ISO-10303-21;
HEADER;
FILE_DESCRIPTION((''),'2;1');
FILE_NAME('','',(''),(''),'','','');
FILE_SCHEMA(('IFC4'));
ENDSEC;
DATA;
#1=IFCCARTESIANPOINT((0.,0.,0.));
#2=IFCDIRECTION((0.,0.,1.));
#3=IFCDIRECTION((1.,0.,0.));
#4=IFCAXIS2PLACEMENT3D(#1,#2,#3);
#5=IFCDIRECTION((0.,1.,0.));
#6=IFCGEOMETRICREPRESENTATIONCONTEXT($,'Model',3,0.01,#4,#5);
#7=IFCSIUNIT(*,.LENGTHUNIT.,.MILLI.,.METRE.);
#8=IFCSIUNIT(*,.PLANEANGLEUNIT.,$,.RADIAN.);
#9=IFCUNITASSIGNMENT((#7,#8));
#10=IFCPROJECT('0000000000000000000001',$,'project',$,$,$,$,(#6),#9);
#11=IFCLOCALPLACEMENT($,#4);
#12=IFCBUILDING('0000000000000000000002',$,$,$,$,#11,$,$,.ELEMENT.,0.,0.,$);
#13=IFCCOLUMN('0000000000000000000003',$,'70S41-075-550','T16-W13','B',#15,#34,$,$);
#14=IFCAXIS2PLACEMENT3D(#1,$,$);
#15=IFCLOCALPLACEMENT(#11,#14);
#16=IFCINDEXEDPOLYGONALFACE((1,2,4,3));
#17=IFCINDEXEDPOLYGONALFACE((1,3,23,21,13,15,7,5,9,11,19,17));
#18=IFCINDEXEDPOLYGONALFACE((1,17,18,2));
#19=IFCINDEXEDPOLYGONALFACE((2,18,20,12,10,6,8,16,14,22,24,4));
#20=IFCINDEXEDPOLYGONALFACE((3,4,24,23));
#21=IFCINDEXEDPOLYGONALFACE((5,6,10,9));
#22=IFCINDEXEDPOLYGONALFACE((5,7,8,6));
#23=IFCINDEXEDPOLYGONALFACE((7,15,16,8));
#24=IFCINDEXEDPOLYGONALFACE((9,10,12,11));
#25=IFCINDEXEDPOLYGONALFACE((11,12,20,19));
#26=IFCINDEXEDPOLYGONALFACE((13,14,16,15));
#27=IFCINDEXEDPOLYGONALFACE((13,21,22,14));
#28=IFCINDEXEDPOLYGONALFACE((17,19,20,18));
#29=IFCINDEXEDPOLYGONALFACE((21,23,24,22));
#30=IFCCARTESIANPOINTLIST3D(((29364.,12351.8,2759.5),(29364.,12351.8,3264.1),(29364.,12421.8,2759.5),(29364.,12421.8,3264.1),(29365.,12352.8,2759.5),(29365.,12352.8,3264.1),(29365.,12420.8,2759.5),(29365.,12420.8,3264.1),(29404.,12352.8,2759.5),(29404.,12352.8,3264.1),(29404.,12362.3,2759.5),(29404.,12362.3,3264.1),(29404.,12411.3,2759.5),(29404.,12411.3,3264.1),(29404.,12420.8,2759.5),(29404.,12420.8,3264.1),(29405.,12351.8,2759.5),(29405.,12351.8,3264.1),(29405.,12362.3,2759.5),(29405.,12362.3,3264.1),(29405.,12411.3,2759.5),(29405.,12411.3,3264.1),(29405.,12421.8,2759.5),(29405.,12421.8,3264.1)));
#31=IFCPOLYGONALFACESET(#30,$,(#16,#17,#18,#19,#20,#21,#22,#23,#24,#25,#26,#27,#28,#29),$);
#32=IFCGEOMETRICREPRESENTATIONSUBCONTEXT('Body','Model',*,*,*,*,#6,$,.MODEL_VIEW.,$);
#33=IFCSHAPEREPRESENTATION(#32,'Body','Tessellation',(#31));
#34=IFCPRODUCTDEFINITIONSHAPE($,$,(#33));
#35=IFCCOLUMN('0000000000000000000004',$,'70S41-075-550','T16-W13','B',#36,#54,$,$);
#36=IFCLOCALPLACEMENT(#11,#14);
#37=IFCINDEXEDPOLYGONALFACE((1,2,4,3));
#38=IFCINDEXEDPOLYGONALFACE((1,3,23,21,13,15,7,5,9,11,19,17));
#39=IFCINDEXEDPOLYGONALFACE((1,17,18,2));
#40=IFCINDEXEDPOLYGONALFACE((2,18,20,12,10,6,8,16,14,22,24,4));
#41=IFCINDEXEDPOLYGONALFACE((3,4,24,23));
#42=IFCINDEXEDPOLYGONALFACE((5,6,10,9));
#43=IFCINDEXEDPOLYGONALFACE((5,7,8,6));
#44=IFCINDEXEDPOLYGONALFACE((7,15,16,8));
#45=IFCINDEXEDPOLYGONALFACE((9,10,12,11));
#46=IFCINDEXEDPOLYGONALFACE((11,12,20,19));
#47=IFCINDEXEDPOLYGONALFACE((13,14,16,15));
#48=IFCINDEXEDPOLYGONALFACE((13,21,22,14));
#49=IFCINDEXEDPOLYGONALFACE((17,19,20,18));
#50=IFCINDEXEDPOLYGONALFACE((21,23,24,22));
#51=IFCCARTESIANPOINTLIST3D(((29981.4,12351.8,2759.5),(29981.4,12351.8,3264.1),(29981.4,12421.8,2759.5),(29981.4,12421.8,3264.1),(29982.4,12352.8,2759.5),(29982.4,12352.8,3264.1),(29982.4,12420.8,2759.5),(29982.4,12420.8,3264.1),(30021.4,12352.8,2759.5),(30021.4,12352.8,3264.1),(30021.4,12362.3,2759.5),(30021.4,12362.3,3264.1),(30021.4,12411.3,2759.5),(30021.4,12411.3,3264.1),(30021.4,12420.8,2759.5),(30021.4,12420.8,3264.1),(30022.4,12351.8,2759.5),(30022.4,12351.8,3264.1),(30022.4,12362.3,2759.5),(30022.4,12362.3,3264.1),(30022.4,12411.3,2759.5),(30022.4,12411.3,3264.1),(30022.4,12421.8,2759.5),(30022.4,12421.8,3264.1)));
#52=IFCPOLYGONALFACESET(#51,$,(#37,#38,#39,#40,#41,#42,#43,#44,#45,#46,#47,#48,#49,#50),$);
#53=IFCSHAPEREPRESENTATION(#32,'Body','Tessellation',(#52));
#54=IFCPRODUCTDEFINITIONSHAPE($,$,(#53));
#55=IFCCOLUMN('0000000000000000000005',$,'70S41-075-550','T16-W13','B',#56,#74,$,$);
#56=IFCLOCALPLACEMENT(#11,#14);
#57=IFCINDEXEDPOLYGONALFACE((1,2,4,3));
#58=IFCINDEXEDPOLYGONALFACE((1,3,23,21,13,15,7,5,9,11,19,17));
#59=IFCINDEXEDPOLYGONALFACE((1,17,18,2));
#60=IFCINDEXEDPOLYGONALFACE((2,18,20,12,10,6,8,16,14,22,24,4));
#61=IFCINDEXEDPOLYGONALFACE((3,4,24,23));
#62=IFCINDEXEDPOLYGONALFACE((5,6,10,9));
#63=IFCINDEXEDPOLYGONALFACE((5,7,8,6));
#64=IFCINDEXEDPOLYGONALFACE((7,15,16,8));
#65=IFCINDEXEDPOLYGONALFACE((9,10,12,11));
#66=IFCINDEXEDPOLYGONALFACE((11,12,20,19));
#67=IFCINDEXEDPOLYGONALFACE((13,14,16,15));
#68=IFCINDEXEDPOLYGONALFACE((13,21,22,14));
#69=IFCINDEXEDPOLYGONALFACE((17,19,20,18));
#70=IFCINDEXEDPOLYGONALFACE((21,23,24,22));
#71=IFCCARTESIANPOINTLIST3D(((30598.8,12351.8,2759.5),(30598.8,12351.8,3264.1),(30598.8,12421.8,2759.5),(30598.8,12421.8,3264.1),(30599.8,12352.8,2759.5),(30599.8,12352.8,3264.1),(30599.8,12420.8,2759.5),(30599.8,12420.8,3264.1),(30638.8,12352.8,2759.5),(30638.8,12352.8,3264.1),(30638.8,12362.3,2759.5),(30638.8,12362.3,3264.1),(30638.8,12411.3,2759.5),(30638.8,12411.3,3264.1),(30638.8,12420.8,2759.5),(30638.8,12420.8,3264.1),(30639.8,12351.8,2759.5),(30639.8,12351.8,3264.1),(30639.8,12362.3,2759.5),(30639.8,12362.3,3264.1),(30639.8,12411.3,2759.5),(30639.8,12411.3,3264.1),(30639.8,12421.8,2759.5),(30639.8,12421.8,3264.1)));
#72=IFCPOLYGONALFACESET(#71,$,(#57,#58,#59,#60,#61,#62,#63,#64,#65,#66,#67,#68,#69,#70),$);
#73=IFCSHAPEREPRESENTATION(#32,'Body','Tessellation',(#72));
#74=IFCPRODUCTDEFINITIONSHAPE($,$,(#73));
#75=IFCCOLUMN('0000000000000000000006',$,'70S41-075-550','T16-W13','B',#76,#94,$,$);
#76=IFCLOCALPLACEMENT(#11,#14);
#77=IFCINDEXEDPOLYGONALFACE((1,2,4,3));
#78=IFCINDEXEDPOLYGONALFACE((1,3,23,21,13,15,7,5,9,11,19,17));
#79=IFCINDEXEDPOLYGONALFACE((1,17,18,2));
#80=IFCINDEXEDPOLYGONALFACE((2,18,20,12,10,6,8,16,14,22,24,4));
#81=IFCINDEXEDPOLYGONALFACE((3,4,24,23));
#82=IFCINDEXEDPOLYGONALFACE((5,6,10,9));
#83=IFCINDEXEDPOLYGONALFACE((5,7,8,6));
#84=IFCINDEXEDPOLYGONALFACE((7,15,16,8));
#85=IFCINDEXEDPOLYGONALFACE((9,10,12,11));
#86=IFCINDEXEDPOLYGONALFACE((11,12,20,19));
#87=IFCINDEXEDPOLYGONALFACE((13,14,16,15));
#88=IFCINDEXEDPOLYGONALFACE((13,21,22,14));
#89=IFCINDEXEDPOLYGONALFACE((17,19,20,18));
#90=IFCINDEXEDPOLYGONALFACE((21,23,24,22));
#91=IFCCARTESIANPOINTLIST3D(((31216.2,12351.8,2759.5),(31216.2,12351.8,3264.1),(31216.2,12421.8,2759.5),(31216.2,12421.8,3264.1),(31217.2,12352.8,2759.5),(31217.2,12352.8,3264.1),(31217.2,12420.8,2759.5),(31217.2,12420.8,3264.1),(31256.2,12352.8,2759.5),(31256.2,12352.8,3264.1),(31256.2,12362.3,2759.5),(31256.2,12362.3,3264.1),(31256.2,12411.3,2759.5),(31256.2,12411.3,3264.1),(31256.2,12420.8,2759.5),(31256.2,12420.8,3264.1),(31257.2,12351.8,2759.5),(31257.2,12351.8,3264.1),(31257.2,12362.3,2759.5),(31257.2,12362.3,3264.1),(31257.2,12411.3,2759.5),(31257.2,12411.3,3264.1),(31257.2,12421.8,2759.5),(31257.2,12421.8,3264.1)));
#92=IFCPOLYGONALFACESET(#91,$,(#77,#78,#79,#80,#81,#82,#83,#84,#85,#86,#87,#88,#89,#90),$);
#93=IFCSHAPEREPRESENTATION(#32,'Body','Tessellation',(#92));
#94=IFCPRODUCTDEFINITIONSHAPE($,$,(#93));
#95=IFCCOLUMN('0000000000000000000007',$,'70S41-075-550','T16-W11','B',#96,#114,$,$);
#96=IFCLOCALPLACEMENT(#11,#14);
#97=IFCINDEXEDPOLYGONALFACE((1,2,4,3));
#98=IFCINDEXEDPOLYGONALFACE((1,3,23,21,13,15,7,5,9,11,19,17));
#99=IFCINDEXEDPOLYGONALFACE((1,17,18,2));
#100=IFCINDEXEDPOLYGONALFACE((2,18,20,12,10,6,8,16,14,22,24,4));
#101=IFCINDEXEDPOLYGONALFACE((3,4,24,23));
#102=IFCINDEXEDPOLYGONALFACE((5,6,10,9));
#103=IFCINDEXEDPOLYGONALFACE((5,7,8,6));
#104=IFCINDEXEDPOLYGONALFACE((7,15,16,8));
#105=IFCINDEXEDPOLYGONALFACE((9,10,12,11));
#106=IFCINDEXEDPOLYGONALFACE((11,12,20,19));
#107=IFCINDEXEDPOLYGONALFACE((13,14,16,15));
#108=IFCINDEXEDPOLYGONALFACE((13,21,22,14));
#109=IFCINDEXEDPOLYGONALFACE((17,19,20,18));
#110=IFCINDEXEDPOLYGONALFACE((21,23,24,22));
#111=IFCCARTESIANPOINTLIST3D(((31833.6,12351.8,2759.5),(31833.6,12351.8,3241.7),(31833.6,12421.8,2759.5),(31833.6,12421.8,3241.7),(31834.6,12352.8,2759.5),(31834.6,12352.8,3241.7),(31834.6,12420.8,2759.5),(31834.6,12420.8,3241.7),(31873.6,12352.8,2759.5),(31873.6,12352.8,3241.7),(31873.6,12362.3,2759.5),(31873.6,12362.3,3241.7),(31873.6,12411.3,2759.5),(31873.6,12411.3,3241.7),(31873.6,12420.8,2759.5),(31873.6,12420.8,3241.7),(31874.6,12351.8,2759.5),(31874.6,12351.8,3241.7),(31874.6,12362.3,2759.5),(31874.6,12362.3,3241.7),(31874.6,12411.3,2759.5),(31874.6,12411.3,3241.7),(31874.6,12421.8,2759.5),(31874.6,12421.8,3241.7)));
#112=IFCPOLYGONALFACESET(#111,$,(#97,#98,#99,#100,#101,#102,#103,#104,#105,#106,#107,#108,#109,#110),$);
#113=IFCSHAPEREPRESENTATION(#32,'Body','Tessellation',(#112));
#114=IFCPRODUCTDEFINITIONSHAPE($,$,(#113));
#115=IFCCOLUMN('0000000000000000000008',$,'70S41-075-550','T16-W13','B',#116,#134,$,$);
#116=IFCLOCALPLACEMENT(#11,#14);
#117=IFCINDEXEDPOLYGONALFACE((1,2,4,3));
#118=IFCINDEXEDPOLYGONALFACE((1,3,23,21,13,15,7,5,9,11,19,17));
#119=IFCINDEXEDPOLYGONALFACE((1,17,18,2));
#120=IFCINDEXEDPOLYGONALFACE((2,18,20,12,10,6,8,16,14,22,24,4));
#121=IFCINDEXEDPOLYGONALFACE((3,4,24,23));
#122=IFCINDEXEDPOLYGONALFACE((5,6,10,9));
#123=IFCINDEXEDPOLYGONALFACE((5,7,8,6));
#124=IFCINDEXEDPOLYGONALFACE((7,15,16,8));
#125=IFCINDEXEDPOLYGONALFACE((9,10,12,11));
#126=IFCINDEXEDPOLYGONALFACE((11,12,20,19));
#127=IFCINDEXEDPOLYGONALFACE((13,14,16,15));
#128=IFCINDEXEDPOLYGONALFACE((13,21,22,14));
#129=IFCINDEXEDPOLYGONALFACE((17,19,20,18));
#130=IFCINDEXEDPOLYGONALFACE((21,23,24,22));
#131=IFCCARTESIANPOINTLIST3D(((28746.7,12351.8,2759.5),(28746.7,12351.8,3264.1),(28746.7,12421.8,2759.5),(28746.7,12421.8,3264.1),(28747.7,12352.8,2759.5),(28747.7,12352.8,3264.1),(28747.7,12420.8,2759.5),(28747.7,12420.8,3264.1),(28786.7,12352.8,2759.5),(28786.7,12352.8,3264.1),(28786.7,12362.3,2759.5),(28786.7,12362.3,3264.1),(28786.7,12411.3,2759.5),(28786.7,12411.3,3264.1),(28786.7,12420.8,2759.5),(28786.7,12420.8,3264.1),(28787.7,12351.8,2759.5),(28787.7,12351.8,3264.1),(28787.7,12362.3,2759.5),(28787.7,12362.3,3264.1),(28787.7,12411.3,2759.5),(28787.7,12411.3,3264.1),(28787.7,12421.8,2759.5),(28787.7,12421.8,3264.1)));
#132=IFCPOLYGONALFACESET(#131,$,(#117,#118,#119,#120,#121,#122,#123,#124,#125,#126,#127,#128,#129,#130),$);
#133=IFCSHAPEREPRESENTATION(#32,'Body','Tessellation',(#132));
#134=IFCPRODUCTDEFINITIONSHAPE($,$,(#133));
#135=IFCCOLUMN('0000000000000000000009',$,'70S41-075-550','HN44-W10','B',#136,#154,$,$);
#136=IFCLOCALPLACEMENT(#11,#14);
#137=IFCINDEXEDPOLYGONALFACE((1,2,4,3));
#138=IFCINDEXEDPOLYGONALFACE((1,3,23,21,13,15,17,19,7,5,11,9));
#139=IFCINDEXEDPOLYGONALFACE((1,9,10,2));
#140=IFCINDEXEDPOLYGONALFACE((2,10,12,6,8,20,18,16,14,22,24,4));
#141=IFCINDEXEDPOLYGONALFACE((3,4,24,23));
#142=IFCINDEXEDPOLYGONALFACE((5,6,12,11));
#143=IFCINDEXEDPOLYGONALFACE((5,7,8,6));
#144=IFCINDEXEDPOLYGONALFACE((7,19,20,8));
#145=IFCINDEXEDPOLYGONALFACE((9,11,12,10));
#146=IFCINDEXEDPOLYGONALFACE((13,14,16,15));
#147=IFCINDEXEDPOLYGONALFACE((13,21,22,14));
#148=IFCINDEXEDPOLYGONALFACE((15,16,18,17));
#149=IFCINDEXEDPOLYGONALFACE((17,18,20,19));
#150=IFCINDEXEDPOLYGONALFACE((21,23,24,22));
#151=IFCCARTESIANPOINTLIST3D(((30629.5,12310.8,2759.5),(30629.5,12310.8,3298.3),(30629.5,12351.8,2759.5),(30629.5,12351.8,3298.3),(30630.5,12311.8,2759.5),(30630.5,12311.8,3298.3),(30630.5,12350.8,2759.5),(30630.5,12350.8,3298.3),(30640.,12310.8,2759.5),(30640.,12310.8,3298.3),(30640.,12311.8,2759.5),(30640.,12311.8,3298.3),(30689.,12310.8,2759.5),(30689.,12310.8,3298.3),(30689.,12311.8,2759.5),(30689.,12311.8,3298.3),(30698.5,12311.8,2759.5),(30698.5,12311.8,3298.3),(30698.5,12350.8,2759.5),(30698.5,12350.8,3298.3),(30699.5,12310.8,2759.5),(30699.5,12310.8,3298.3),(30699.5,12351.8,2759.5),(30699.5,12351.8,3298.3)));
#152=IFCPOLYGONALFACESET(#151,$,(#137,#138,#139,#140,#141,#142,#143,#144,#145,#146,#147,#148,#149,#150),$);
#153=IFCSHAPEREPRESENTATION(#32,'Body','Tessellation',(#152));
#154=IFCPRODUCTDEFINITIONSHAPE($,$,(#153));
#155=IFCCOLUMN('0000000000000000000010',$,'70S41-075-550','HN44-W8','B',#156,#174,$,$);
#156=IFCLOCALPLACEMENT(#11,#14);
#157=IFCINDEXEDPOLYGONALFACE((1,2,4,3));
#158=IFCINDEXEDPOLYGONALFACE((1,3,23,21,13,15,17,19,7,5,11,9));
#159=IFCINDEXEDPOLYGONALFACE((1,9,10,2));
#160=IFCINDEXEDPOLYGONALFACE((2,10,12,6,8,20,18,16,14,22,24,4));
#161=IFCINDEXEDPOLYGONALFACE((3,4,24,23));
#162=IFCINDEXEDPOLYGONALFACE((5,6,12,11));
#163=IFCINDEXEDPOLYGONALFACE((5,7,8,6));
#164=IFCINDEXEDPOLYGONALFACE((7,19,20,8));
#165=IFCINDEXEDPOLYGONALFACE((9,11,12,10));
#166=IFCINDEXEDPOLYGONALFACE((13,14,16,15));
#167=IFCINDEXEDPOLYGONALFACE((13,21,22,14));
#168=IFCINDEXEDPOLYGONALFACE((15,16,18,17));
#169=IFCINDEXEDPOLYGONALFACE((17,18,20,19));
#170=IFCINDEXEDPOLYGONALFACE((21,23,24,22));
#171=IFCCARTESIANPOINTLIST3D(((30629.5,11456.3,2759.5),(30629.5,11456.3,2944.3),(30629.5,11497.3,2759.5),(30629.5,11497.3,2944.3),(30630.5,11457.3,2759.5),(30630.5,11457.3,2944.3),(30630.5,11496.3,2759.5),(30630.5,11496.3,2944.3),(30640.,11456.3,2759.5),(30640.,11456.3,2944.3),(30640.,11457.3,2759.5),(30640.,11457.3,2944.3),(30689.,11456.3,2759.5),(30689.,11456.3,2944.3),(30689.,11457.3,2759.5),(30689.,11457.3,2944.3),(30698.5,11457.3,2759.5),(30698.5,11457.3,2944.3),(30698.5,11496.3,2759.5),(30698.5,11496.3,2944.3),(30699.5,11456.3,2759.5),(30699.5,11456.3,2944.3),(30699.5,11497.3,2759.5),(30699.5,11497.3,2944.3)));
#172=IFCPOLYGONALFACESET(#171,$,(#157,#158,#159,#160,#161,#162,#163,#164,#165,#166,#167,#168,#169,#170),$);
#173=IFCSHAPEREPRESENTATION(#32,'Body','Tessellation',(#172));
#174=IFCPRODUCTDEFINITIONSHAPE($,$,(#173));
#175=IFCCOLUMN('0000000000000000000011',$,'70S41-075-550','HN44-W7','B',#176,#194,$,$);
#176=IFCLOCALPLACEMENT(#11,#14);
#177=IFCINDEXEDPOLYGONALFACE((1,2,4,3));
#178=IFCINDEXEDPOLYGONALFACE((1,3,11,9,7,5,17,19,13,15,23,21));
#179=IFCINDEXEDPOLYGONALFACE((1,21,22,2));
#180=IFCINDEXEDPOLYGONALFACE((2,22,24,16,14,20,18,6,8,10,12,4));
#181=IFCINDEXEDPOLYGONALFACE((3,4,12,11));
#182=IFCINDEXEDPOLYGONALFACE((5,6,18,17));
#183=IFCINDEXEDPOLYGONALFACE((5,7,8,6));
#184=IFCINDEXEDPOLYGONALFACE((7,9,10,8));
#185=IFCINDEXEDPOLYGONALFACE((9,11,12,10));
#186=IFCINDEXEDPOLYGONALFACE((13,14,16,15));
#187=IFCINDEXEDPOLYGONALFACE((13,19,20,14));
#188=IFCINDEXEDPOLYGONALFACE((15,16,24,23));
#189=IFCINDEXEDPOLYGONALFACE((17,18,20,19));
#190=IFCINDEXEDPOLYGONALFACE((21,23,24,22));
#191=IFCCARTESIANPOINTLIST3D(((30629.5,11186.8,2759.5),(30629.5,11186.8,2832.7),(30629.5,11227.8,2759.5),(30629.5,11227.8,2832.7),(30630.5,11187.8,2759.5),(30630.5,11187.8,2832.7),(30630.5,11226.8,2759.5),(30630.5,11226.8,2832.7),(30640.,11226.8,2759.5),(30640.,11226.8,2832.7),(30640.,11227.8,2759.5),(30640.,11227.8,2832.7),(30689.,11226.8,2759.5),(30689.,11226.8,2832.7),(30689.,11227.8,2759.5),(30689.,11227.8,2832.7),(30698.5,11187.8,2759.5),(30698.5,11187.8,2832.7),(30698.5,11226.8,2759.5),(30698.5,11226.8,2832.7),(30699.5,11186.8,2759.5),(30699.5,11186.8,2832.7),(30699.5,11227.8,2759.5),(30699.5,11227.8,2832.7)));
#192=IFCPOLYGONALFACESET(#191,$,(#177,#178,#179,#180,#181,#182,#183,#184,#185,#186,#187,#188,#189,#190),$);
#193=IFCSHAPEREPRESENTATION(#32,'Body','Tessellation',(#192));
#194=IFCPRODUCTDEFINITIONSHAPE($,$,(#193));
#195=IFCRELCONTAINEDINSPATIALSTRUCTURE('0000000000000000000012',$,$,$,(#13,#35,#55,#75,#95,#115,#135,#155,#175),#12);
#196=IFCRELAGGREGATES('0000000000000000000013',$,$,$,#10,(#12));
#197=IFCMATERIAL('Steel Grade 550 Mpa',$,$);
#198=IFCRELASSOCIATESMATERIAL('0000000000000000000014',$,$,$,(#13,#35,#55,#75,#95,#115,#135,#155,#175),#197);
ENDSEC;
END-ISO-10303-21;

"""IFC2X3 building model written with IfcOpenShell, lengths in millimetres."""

from ifc_helpers import new_model, si_unit, direction, frame, origin, origin_with_axes, origin_2d_with_axis, place, context, subcontext, project, spatial, c_section, extrude, source, transform, mapped, material, element, save


model = new_model("IFC2X3")

# Units and contexts
model_context = context("Model", 3, precision=0.01, world=origin_with_axes(), true_north=direction((0.0, 1.0, 0.0)))
body_context = subcontext(model_context, "Body", "Model", "MODEL_VIEW")
ifc_project = project(units=[si_unit("LENGTHUNIT", "METRE", prefix="MILLI"), si_unit("PLANEANGLEUNIT", "RADIAN")], contexts=[model_context])

# Building
building_placement = place(None, origin_with_axes())
building = spatial("IfcBuilding", under=ifc_project, at=building_placement, CompositionType="ELEMENT", ElevationOfRefHeight=0.0, ElevationOfTerrain=0.0)

# Columns
ifc_material = material(Name="Steel Grade 550 Mpa")
shared_shape_1 = source(origin(), body_context, "Body", "SweptSolid", [
    extrude(c_section(Depth=70.0, Width=41.0, WallThickness=1.0, Girth=10.5, at=origin_2d_with_axis()), origin_with_axes(), (0.0, 0.0, 1.0), 504.6),
])
column_1_placement = place(None, frame((29384.5, 12386.8, 2759.5), z_axis=(0.0, 0.0, 1.0), x_axis=(1.0, 0.0, 0.0)))
element("IfcColumn", 1, at=column_1_placement, inside=building, material=ifc_material, Name="70S41-075-550", Description="T16-W13", ObjectType="B", context=body_context, shape_type="MappedRepresentation", body=[
    mapped(shared_shape_1, transform((0.0, 0.0, 0.0), scale=1.0)),
])
shared_shape_2 = source(origin(), body_context, "Body", "SweptSolid", [
    extrude(c_section(Depth=70.0, Width=41.0, WallThickness=1.0, Girth=10.5, at=origin_2d_with_axis()), origin_with_axes(), (0.0, 0.0, 1.0), 504.6),
])
column_2_placement = place(None, frame((30001.9, 12386.8, 2759.5), z_axis=(0.0, 0.0, 1.0), x_axis=(1.0, 0.0, 0.0)))
element("IfcColumn", 2, at=column_2_placement, inside=building, material=ifc_material, Name="70S41-075-550", Description="T16-W13", ObjectType="B", context=body_context, shape_type="MappedRepresentation", body=[
    mapped(shared_shape_2, transform((0.0, 0.0, 0.0), scale=1.0)),
])
shared_shape_3 = source(origin(), body_context, "Body", "SweptSolid", [
    extrude(c_section(Depth=70.0, Width=41.0, WallThickness=1.0, Girth=10.5, at=origin_2d_with_axis()), origin_with_axes(), (0.0, 0.0, 1.0), 504.6),
])
column_3_placement = place(None, frame((30619.3, 12386.8, 2759.5), z_axis=(0.0, 0.0, 1.0), x_axis=(1.0, 0.0, 0.0)))
element("IfcColumn", 3, at=column_3_placement, inside=building, material=ifc_material, Name="70S41-075-550", Description="T16-W13", ObjectType="B", context=body_context, shape_type="MappedRepresentation", body=[
    mapped(shared_shape_3, transform((0.0, 0.0, 0.0), scale=1.0)),
])
shared_shape_4 = source(origin(), body_context, "Body", "SweptSolid", [
    extrude(c_section(Depth=70.0, Width=41.0, WallThickness=1.0, Girth=10.5, at=origin_2d_with_axis()), origin_with_axes(), (0.0, 0.0, 1.0), 504.6),
])
column_4_placement = place(None, frame((31236.7, 12386.8, 2759.5), z_axis=(0.0, 0.0, 1.0), x_axis=(1.0, 0.0, 0.0)))
element("IfcColumn", 4, at=column_4_placement, inside=building, material=ifc_material, Name="70S41-075-550", Description="T16-W13", ObjectType="B", context=body_context, shape_type="MappedRepresentation", body=[
    mapped(shared_shape_4, transform((0.0, 0.0, 0.0), scale=1.0)),
])
shared_shape_5 = source(origin(), body_context, "Body", "SweptSolid", [
    extrude(c_section(Depth=70.0, Width=41.0, WallThickness=1.0, Girth=10.5, at=origin_2d_with_axis()), origin_with_axes(), (0.0, 0.0, 1.0), 482.2),
])
column_5_placement = place(None, frame((31854.1, 12386.8, 2759.5), z_axis=(0.0, 0.0, 1.0), x_axis=(1.0, 0.0, 0.0)))
element("IfcColumn", 5, at=column_5_placement, inside=building, material=ifc_material, Name="70S41-075-550", Description="T16-W11", ObjectType="B", context=body_context, shape_type="MappedRepresentation", body=[
    mapped(shared_shape_5, transform((0.0, 0.0, 0.0), scale=1.0)),
])
shared_shape_6 = source(origin(), body_context, "Body", "SweptSolid", [
    extrude(c_section(Depth=70.0, Width=41.0, WallThickness=1.0, Girth=10.5, at=origin_2d_with_axis()), origin_with_axes(), (0.0, 0.0, 1.0), 504.6),
])
column_6_placement = place(None, frame((28767.2, 12386.8, 2759.5), z_axis=(0.0, 0.0, 1.0), x_axis=(1.0, 0.0, 0.0)))
element("IfcColumn", 6, at=column_6_placement, inside=building, material=ifc_material, Name="70S41-075-550", Description="T16-W13", ObjectType="B", context=body_context, shape_type="MappedRepresentation", body=[
    mapped(shared_shape_6, transform((0.0, 0.0, 0.0), scale=1.0)),
])
shared_shape_7 = source(origin(), body_context, "Body", "SweptSolid", [
    extrude(c_section(Depth=70.0, Width=41.0, WallThickness=1.0, Girth=10.5, at=origin_2d_with_axis()), origin_with_axes(), (0.0, 0.0, 1.0), 538.8),
])
column_7_placement = place(None, frame((30664.5, 12331.3, 2759.5), z_axis=(0.0, 0.0, 1.0), x_axis=(0.0, -1.0, 0.0)))
element("IfcColumn", 7, at=column_7_placement, inside=building, material=ifc_material, Name="70S41-075-550", Description="HN44-W10", ObjectType="B", context=body_context, shape_type="MappedRepresentation", body=[
    mapped(shared_shape_7, transform((0.0, 0.0, 0.0), scale=1.0)),
])
shared_shape_8 = source(origin(), body_context, "Body", "SweptSolid", [
    extrude(c_section(Depth=70.0, Width=41.0, WallThickness=1.0, Girth=10.5, at=origin_2d_with_axis()), origin_with_axes(), (0.0, 0.0, 1.0), 184.8),
])
column_8_placement = place(None, frame((30664.5, 11476.8, 2759.5), z_axis=(0.0, 0.0, 1.0), x_axis=(0.0, -1.0, 0.0)))
element("IfcColumn", 8, at=column_8_placement, inside=building, material=ifc_material, Name="70S41-075-550", Description="HN44-W8", ObjectType="B", context=body_context, shape_type="MappedRepresentation", body=[
    mapped(shared_shape_8, transform((0.0, 0.0, 0.0), scale=1.0)),
])
shared_shape_9 = source(origin(), body_context, "Body", "SweptSolid", [
    extrude(c_section(Depth=70.0, Width=41.0, WallThickness=1.0, Girth=10.5, at=origin_2d_with_axis()), origin_with_axes(), (0.0, 0.0, 1.0), 73.2),
])
column_9_placement = place(None, frame((30664.5, 11207.3, 2832.7), z_axis=(0.0, 0.0, -1.0), x_axis=(0.0, 1.0, 0.0)))
element("IfcColumn", 9, at=column_9_placement, inside=building, material=ifc_material, Name="70S41-075-550", Description="HN44-W7", ObjectType="B", context=body_context, shape_type="MappedRepresentation", body=[
    mapped(shared_shape_9, transform((0.0, 0.0, 0.0), scale=1.0)),
])

save(model, "model.ifc")
